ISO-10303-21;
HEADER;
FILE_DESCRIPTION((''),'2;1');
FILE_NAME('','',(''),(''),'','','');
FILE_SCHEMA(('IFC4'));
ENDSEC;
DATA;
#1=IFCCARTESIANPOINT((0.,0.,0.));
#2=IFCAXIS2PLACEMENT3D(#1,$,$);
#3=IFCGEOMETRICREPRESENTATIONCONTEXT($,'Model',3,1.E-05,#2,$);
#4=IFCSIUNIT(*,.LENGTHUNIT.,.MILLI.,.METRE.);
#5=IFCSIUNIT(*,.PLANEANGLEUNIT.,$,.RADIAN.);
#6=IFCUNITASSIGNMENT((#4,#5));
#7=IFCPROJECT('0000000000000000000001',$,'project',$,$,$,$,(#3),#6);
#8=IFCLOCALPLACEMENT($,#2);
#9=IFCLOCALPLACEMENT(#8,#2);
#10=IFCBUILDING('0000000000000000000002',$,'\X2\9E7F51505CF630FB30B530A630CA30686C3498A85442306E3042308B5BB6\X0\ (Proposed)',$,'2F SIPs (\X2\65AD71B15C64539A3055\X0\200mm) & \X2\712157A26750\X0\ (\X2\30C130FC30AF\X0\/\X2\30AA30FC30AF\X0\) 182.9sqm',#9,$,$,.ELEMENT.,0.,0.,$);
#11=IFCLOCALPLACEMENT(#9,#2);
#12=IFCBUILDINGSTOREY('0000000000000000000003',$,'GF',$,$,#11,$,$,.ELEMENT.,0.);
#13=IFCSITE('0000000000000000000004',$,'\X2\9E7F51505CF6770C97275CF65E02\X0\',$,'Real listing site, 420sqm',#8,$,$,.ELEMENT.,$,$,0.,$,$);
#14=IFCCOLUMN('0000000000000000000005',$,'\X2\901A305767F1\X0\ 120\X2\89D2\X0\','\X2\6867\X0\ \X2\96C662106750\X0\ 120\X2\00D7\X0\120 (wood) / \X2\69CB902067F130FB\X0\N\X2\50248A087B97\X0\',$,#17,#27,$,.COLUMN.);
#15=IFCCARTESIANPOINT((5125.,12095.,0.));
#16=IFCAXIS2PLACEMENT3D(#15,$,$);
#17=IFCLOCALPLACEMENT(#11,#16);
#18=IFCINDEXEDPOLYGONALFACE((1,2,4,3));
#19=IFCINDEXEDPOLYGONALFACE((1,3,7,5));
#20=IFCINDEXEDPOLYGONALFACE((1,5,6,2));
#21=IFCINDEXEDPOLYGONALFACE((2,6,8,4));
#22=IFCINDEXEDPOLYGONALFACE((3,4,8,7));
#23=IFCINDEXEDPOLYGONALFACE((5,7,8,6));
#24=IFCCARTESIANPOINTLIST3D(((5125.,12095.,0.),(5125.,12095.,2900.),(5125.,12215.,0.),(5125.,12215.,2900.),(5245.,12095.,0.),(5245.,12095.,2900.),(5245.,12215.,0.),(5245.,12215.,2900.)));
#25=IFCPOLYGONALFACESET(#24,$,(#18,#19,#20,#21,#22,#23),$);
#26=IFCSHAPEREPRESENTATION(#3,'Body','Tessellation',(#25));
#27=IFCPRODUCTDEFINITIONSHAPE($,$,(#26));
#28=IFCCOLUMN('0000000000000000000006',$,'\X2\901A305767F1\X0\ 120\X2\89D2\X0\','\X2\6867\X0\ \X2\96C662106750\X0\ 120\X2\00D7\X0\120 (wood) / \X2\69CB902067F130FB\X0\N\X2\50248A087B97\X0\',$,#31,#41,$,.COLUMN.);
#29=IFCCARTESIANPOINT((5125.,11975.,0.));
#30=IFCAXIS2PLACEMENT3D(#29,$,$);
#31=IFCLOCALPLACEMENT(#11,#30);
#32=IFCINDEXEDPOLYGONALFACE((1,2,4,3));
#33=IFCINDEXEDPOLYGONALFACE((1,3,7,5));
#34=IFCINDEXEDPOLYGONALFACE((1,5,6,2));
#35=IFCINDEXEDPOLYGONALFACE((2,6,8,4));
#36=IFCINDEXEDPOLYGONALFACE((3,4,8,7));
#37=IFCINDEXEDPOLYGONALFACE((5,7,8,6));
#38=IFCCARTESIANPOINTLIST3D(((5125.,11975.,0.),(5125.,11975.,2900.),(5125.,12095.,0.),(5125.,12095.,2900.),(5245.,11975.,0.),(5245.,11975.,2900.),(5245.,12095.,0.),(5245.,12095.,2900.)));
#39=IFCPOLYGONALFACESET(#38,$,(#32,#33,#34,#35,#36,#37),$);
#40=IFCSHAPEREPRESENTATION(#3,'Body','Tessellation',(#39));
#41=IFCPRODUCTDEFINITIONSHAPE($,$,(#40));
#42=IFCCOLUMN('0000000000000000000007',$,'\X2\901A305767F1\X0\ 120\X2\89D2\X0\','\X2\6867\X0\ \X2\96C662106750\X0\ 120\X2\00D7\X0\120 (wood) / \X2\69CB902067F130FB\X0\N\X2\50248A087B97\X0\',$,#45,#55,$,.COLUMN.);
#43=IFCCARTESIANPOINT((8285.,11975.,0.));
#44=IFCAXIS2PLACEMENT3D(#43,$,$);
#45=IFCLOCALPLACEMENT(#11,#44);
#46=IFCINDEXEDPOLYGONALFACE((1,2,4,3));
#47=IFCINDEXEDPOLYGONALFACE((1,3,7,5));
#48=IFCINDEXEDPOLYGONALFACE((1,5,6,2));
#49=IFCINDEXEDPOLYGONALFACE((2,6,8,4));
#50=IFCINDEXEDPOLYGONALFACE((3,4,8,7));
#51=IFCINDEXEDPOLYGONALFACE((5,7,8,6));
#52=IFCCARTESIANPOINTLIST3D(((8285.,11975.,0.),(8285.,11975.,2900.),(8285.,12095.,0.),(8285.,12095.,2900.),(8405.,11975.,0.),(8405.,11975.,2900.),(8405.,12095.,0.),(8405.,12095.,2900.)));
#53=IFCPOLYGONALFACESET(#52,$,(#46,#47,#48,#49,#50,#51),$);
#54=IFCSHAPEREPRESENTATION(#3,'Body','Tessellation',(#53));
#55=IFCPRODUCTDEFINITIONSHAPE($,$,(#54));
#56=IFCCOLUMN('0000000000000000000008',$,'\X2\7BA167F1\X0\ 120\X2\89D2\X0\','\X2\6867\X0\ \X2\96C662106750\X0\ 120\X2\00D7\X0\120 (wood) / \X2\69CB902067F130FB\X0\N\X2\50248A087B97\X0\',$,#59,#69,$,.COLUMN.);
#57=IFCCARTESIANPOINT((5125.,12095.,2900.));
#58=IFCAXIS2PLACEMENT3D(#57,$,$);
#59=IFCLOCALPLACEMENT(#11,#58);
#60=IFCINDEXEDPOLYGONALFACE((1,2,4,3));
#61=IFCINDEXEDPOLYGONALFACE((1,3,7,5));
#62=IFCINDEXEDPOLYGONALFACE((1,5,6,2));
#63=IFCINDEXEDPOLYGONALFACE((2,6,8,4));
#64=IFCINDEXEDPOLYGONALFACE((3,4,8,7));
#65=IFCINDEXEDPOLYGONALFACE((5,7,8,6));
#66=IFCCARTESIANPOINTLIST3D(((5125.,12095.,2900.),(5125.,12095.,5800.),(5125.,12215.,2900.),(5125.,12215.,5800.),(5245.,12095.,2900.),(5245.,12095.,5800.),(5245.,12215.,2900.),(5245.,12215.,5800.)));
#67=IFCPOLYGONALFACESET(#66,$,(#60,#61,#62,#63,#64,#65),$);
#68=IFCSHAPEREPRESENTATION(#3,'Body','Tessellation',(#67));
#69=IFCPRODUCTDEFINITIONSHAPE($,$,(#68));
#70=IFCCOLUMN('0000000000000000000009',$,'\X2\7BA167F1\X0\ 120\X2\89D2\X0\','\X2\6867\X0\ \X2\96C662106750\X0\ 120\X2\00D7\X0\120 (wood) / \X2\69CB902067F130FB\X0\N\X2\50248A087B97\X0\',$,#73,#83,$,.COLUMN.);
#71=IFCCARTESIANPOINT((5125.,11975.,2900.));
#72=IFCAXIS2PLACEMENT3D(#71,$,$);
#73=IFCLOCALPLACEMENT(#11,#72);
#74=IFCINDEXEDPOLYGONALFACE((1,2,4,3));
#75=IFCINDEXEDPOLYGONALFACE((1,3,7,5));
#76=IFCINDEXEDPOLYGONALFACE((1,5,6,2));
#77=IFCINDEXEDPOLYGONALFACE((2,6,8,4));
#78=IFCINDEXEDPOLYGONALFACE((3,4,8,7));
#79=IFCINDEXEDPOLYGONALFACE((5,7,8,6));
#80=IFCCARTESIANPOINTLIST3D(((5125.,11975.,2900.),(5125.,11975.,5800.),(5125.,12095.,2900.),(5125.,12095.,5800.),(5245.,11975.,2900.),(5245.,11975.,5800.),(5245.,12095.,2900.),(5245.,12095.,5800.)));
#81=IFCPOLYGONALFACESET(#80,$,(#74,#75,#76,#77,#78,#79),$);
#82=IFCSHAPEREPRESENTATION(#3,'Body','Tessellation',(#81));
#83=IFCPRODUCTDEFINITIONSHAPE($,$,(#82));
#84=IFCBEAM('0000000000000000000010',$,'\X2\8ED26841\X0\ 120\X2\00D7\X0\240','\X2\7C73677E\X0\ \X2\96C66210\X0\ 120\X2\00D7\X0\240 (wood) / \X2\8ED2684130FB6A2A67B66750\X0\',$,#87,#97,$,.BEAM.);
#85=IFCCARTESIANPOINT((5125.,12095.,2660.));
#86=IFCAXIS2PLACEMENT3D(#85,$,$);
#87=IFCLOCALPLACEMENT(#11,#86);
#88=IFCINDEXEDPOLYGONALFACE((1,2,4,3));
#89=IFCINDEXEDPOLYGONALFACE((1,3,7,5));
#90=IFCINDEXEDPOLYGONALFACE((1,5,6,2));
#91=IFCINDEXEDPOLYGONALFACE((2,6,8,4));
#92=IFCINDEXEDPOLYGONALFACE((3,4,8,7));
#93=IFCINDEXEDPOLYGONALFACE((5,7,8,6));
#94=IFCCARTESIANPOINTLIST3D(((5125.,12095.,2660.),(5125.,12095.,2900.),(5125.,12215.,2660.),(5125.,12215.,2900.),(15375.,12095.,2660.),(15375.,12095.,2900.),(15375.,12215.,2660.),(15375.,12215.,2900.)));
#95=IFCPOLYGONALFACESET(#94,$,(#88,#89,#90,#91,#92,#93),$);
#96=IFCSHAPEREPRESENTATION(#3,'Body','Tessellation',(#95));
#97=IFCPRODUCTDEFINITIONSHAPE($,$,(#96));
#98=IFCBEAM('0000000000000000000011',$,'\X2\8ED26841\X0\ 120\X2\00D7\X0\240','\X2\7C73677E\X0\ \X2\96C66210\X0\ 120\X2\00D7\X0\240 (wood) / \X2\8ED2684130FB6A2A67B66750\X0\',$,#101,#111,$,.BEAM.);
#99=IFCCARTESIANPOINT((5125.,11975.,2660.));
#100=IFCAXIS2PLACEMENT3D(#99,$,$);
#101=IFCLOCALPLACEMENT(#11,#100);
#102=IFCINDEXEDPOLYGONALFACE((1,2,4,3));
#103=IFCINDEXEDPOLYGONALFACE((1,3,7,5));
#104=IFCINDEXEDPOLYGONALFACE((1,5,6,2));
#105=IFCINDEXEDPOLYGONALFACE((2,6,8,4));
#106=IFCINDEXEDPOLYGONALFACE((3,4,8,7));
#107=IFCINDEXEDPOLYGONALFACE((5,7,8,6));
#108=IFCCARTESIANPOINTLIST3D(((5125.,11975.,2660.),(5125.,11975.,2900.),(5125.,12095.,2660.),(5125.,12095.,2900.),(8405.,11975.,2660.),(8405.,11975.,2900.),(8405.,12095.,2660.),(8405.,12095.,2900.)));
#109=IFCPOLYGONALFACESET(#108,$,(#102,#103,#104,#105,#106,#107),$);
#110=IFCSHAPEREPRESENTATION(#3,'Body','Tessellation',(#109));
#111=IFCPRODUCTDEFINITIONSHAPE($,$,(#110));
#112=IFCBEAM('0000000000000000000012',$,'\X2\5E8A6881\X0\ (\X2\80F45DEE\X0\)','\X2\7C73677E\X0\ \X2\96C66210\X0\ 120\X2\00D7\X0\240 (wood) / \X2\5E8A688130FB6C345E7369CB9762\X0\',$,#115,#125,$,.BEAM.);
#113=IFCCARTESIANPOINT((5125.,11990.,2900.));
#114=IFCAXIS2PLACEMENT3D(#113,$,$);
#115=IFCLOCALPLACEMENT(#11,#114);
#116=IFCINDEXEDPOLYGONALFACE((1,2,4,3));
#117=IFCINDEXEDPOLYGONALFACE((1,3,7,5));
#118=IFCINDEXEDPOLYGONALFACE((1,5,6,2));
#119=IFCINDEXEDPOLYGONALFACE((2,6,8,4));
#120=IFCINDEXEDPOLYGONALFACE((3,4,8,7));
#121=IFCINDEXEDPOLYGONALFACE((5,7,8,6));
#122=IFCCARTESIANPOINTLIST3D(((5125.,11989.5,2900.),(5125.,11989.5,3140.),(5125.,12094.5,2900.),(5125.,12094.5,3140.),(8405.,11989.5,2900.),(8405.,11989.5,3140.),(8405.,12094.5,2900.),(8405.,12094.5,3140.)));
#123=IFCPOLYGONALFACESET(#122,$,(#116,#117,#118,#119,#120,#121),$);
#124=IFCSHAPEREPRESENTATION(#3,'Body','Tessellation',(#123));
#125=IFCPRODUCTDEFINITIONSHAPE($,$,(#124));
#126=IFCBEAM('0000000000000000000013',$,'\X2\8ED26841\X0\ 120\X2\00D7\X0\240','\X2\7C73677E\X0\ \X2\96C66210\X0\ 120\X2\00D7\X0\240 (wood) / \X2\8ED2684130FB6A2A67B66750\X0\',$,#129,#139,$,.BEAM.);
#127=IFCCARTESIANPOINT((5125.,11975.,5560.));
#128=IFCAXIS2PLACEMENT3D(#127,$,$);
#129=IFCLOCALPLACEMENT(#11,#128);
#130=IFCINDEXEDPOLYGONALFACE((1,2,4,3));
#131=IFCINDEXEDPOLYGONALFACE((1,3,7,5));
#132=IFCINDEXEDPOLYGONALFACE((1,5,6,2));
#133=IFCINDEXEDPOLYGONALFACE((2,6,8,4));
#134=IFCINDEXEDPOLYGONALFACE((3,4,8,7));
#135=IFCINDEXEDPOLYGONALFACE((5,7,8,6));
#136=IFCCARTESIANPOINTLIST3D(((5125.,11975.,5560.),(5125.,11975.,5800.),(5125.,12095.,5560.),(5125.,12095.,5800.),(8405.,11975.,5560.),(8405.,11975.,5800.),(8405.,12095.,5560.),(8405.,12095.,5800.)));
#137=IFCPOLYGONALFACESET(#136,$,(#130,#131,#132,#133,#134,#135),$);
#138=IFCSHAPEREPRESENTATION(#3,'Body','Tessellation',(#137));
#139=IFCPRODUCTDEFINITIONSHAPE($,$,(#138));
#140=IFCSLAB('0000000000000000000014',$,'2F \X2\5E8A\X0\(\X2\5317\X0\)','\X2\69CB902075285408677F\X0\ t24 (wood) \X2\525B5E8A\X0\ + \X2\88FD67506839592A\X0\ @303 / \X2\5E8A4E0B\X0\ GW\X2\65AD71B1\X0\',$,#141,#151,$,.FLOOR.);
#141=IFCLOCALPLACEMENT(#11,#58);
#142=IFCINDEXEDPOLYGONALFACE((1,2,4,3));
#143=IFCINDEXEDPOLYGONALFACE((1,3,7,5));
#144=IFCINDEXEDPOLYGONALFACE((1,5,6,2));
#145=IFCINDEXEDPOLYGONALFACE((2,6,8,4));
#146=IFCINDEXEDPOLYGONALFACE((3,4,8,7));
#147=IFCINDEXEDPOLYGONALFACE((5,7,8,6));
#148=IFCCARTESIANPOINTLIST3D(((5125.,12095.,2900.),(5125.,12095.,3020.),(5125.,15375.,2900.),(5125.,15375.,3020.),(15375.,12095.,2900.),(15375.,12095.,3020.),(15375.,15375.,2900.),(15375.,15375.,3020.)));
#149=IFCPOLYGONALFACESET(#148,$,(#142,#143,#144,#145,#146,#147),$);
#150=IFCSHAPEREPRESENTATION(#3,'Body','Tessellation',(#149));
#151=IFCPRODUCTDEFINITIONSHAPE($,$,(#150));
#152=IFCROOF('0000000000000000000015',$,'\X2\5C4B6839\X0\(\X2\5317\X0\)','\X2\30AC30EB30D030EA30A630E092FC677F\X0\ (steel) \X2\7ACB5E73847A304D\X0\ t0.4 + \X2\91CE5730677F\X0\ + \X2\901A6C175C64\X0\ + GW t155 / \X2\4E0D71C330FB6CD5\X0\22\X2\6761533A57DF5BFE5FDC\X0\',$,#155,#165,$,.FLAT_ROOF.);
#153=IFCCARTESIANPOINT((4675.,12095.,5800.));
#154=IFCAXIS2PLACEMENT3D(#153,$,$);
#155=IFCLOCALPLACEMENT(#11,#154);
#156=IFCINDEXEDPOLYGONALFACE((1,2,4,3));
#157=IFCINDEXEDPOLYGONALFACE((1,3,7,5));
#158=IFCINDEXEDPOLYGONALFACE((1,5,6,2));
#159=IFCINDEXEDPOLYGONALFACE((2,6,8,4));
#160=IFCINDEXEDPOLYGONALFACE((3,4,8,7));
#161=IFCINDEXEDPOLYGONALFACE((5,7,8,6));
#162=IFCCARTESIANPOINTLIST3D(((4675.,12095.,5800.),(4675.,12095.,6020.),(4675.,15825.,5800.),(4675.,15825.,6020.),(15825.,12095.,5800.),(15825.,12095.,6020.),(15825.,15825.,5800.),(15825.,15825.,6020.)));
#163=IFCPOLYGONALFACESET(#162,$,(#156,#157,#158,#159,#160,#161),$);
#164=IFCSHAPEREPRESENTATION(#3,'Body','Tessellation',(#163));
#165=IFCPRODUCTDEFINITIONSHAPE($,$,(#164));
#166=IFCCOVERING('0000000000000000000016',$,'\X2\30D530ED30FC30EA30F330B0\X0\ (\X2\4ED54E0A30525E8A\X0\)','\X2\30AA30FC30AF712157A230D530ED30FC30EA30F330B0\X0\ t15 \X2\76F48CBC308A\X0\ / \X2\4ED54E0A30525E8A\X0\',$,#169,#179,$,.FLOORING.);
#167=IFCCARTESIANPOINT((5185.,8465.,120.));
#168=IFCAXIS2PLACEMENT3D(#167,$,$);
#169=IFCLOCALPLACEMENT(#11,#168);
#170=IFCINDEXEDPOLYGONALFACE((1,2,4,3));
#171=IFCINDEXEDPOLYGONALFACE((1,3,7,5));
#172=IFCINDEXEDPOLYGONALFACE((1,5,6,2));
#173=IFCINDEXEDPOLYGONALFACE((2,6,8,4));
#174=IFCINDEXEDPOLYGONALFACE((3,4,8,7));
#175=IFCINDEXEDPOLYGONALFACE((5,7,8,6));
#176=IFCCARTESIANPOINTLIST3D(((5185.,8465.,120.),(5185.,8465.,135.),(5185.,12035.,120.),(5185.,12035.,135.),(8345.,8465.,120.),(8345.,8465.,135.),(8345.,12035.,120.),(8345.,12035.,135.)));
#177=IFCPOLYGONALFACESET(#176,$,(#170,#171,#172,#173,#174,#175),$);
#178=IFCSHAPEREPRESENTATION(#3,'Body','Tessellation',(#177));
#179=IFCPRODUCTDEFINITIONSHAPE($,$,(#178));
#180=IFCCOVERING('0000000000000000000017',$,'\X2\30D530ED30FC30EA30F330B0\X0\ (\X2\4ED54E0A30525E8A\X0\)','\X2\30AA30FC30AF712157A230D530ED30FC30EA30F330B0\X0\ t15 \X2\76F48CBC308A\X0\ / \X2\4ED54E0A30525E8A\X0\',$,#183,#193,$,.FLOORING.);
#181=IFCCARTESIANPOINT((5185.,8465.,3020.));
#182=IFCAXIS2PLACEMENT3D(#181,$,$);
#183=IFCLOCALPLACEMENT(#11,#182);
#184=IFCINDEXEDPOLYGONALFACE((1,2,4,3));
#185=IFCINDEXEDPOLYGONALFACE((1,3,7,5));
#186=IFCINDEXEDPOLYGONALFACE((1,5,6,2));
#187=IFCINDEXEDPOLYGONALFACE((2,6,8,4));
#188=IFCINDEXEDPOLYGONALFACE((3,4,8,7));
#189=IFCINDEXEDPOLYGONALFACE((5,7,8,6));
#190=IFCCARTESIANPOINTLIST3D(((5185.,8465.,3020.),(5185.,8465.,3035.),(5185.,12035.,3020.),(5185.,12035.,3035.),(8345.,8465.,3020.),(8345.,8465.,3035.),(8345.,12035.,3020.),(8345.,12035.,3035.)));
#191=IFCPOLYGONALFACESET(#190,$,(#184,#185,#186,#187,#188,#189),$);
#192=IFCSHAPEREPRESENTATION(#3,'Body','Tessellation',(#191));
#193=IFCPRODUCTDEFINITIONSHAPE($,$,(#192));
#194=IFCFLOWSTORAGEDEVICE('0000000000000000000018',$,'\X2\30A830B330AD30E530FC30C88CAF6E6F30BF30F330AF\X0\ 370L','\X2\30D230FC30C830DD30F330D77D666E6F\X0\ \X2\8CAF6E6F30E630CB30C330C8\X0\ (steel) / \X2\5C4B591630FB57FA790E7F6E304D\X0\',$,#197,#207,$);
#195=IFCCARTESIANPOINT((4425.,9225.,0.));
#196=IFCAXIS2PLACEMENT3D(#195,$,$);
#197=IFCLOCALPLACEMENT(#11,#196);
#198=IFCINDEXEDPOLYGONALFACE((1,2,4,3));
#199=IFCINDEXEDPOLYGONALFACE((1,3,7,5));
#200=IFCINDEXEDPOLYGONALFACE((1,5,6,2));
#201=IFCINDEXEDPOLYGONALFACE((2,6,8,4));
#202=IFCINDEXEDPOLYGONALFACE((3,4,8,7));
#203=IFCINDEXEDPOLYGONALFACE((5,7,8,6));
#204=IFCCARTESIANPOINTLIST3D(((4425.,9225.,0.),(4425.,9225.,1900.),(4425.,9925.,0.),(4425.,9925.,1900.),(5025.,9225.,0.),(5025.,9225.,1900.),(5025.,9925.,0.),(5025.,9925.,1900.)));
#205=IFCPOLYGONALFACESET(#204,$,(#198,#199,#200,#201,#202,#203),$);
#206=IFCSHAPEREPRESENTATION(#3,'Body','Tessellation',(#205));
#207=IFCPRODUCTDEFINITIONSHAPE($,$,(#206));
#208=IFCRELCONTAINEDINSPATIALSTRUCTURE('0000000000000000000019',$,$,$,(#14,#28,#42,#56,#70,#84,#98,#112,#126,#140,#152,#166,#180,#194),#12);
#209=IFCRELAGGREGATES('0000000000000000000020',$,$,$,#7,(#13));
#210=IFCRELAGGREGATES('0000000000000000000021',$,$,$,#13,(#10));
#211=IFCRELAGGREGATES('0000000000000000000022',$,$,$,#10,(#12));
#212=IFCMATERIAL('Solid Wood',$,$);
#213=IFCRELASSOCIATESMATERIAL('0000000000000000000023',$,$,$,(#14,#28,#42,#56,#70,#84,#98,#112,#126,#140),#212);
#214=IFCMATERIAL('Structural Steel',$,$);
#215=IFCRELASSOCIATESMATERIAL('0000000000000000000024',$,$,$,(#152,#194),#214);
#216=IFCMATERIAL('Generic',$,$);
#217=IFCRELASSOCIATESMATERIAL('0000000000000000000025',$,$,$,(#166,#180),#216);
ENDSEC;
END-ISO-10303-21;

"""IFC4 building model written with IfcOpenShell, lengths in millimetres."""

from ifc_helpers import new_model, si_unit, frame, frame_2d, origin, place, context, project, spatial, rectangle, extrude, material, element, save


model = new_model("IFC4")

# Units and contexts
model_context = context("Model", 3, precision=1e-05, world=origin())
ifc_project = project(units=[si_unit("LENGTHUNIT", "METRE", prefix="MILLI"), si_unit("PLANEANGLEUNIT", "RADIAN")], contexts=[model_context])

# Site, building, storey
site_placement = place(None, origin())
site = spatial("IfcSite", under=ifc_project, at=site_placement, Name="鹿児島県霧島市", ObjectType="Real listing site, 420sqm", CompositionType="ELEMENT", RefElevation=0.0)
building_placement = place(site_placement, origin())
building = spatial("IfcBuilding", under=site, at=building_placement, Name="鹿児島・サウナと水風呂のある家 (Proposed)", ObjectType="2F SIPs (断熱層厚さ200mm) & 無垢材 (チーク/オーク) 182.9sqm", CompositionType="ELEMENT", ElevationOfRefHeight=0.0, ElevationOfTerrain=0.0)
storey_placement = place(building_placement, origin())
storey = spatial("IfcBuildingStorey", under=building, at=storey_placement, Name="GF", CompositionType="ELEMENT", Elevation=0.0)

# Columns
ifc_material_1 = material(Name="Solid Wood")
column_1_placement = place(storey_placement, frame((5125.0, 12095.0, 0.0)))
element("IfcColumn", 1, at=column_1_placement, inside=storey, material=ifc_material_1, Name="通し柱 120角", Description="桧 集成材 120×120 (wood) / 構造柱・N値計算", PredefinedType="COLUMN", context=model_context, shape_type="SweptSolid", body=[
    extrude(rectangle(XDim=120.0, YDim=120.0, at=frame_2d((60.0, 60.0))), frame((5125.0, 12095.0, 0.0)), (0.0, 0.0, 1.0), 2900.0),
])
column_2_placement = place(storey_placement, frame((5125.0, 11975.0, 0.0)))
element("IfcColumn", 2, at=column_2_placement, inside=storey, material=ifc_material_1, Name="通し柱 120角", Description="桧 集成材 120×120 (wood) / 構造柱・N値計算", PredefinedType="COLUMN", context=model_context, shape_type="SweptSolid", body=[
    extrude(rectangle(XDim=120.0, YDim=120.0, at=frame_2d((60.0, 60.0))), frame((5125.0, 11975.0, 0.0)), (0.0, 0.0, 1.0), 2900.0),
])
column_3_placement = place(storey_placement, frame((8285.0, 11975.0, 0.0)))
element("IfcColumn", 3, at=column_3_placement, inside=storey, material=ifc_material_1, Name="通し柱 120角", Description="桧 集成材 120×120 (wood) / 構造柱・N値計算", PredefinedType="COLUMN", context=model_context, shape_type="SweptSolid", body=[
    extrude(rectangle(XDim=120.0, YDim=120.0, at=frame_2d((60.0, 60.0))), frame((8285.0, 11975.0, 0.0)), (0.0, 0.0, 1.0), 2900.0),
])
column_4_placement = place(storey_placement, frame((5125.0, 12095.0, 2900.0)))
element("IfcColumn", 4, at=column_4_placement, inside=storey, material=ifc_material_1, Name="管柱 120角", Description="桧 集成材 120×120 (wood) / 構造柱・N値計算", PredefinedType="COLUMN", context=model_context, shape_type="SweptSolid", body=[
    extrude(rectangle(XDim=120.0, YDim=120.0, at=frame_2d((60.0, 60.0))), frame((5125.0, 12095.0, 2900.0)), (0.0, 0.0, 1.0), 2900.0),
])
column_5_placement = place(storey_placement, frame((5125.0, 11975.0, 2900.0)))
element("IfcColumn", 5, at=column_5_placement, inside=storey, material=ifc_material_1, Name="管柱 120角", Description="桧 集成材 120×120 (wood) / 構造柱・N値計算", PredefinedType="COLUMN", context=model_context, shape_type="SweptSolid", body=[
    extrude(rectangle(XDim=120.0, YDim=120.0, at=frame_2d((60.0, 60.0))), frame((5125.0, 11975.0, 2900.0)), (0.0, 0.0, 1.0), 2900.0),
])

# Beams
beam_1_placement = place(storey_placement, frame((5125.0, 12095.0, 2660.0)))
element("IfcBeam", 6, at=beam_1_placement, inside=storey, material=ifc_material_1, Name="軒桁 120×240", Description="米松 集成 120×240 (wood) / 軒桁・横架材", PredefinedType="BEAM", context=model_context, shape_type="SweptSolid", body=[
    extrude(rectangle(XDim=10250.0, YDim=120.0, at=frame_2d((5125.0, 60.0))), frame((5125.0, 12095.0, 2660.0)), (0.0, 0.0, 1.0), 240.0),
])
beam_2_placement = place(storey_placement, frame((5125.0, 11975.0, 2660.0)))
element("IfcBeam", 7, at=beam_2_placement, inside=storey, material=ifc_material_1, Name="軒桁 120×240", Description="米松 集成 120×240 (wood) / 軒桁・横架材", PredefinedType="BEAM", context=model_context, shape_type="SweptSolid", body=[
    extrude(rectangle(XDim=3280.0, YDim=120.0, at=frame_2d((1640.0, 60.0))), frame((5125.0, 11975.0, 2660.0)), (0.0, 0.0, 1.0), 240.0),
])
beam_3_placement = place(storey_placement, frame((5125.0, 11990.0, 2900.0)))
element("IfcBeam", 8, at=beam_3_placement, inside=storey, material=ifc_material_1, Name="床梁 (胴差)", Description="米松 集成 120×240 (wood) / 床梁・水平構面", PredefinedType="BEAM", context=model_context, shape_type="SweptSolid", body=[
    extrude(rectangle(XDim=3280.0, YDim=105.0, at=frame_2d((1640.0, 52.0))), frame((5125.0, 11990.0, 2900.0)), (0.0, 0.0, 1.0), 240.0),
])
beam_4_placement = place(storey_placement, frame((5125.0, 11975.0, 5560.0)))
element("IfcBeam", 9, at=beam_4_placement, inside=storey, material=ifc_material_1, Name="軒桁 120×240", Description="米松 集成 120×240 (wood) / 軒桁・横架材", PredefinedType="BEAM", context=model_context, shape_type="SweptSolid", body=[
    extrude(rectangle(XDim=3280.0, YDim=120.0, at=frame_2d((1640.0, 60.0))), frame((5125.0, 11975.0, 5560.0)), (0.0, 0.0, 1.0), 240.0),
])

# Slab
slab_1_placement = place(storey_placement, frame((5125.0, 12095.0, 2900.0)))
element("IfcSlab", 10, at=slab_1_placement, inside=storey, material=ifc_material_1, Name="2F 床(北)", Description="構造用合板 t24 (wood) 剛床 + 製材根太 @303 / 床下 GW断熱", PredefinedType="FLOOR", context=model_context, shape_type="SweptSolid", body=[
    extrude(rectangle(XDim=10250.0, YDim=3280.0, at=frame_2d((5125.0, 1640.0))), frame((5125.0, 12095.0, 2900.0)), (0.0, 0.0, 1.0), 120.0),
])

# Roof
ifc_material_2 = material(Name="Structural Steel")
for number, where, name in (
    (11, (4675.0, 12095.0, 5800.0), "屋根(北)"),
):
    element("IfcRoof", number, at=place(storey_placement, frame(where)), inside=storey, material=ifc_material_2, Name=name, Description="ガルバリウム鋼板 (steel) 立平葺き t0.4 + 野地板 + 通気層 + GW t155 / 不燃・法22条区域対応", PredefinedType="FLAT_ROOF", context=model_context, shape_type="SweptSolid", body=[
        extrude(rectangle(XDim=11150.0, YDim=3730.0, at=frame_2d((5575.0, 1865.0))), frame((4675.0, 12095.0, 5800.0)), (0.0, 0.0, 1.0), 220.0),
    ])

# Coverings
ifc_material_3 = material(Name="Generic")
covering_1_placement = place(storey_placement, frame((5185.0, 8465.0, 120.0)))
element("IfcCovering", 12, at=covering_1_placement, inside=storey, material=ifc_material_3, Name="フローリング (仕上げ床)", Description="オーク無垢フローリング t15 直貼り / 仕上げ床", PredefinedType="FLOORING", context=model_context, shape_type="SweptSolid", body=[
    extrude(rectangle(XDim=3160.0, YDim=3570.0, at=frame_2d((1580.0, 1785.0))), frame((5185.0, 8465.0, 120.0)), (0.0, 0.0, 1.0), 15.0),
])
covering_2_placement = place(storey_placement, frame((5185.0, 8465.0, 3020.0)))
element("IfcCovering", 13, at=covering_2_placement, inside=storey, material=ifc_material_3, Name="フローリング (仕上げ床)", Description="オーク無垢フローリング t15 直貼り / 仕上げ床", PredefinedType="FLOORING", context=model_context, shape_type="SweptSolid", body=[
    extrude(rectangle(XDim=3160.0, YDim=3570.0, at=frame_2d((1580.0, 1785.0))), frame((5185.0, 8465.0, 3020.0)), (0.0, 0.0, 1.0), 15.0),
])

# Flow storage device
flow_storage_device_placement = place(storey_placement, frame((4425.0, 9225.0, 0.0)))
element("IfcFlowStorageDevice", 14, at=flow_storage_device_placement, inside=storey, material=ifc_material_2, Name="エコキュート貯湯タンク 370L", Description="ヒートポンプ給湯 貯湯ユニット (steel) / 屋外・基礎置き", context=model_context, shape_type="SweptSolid", body=[
    extrude(rectangle(XDim=600.0, YDim=700.0, at=frame_2d((300.0, 350.0))), frame((4425.0, 9225.0, 0.0)), (0.0, 0.0, 1.0), 1900.0),
])

save(model, "model.ifc")
